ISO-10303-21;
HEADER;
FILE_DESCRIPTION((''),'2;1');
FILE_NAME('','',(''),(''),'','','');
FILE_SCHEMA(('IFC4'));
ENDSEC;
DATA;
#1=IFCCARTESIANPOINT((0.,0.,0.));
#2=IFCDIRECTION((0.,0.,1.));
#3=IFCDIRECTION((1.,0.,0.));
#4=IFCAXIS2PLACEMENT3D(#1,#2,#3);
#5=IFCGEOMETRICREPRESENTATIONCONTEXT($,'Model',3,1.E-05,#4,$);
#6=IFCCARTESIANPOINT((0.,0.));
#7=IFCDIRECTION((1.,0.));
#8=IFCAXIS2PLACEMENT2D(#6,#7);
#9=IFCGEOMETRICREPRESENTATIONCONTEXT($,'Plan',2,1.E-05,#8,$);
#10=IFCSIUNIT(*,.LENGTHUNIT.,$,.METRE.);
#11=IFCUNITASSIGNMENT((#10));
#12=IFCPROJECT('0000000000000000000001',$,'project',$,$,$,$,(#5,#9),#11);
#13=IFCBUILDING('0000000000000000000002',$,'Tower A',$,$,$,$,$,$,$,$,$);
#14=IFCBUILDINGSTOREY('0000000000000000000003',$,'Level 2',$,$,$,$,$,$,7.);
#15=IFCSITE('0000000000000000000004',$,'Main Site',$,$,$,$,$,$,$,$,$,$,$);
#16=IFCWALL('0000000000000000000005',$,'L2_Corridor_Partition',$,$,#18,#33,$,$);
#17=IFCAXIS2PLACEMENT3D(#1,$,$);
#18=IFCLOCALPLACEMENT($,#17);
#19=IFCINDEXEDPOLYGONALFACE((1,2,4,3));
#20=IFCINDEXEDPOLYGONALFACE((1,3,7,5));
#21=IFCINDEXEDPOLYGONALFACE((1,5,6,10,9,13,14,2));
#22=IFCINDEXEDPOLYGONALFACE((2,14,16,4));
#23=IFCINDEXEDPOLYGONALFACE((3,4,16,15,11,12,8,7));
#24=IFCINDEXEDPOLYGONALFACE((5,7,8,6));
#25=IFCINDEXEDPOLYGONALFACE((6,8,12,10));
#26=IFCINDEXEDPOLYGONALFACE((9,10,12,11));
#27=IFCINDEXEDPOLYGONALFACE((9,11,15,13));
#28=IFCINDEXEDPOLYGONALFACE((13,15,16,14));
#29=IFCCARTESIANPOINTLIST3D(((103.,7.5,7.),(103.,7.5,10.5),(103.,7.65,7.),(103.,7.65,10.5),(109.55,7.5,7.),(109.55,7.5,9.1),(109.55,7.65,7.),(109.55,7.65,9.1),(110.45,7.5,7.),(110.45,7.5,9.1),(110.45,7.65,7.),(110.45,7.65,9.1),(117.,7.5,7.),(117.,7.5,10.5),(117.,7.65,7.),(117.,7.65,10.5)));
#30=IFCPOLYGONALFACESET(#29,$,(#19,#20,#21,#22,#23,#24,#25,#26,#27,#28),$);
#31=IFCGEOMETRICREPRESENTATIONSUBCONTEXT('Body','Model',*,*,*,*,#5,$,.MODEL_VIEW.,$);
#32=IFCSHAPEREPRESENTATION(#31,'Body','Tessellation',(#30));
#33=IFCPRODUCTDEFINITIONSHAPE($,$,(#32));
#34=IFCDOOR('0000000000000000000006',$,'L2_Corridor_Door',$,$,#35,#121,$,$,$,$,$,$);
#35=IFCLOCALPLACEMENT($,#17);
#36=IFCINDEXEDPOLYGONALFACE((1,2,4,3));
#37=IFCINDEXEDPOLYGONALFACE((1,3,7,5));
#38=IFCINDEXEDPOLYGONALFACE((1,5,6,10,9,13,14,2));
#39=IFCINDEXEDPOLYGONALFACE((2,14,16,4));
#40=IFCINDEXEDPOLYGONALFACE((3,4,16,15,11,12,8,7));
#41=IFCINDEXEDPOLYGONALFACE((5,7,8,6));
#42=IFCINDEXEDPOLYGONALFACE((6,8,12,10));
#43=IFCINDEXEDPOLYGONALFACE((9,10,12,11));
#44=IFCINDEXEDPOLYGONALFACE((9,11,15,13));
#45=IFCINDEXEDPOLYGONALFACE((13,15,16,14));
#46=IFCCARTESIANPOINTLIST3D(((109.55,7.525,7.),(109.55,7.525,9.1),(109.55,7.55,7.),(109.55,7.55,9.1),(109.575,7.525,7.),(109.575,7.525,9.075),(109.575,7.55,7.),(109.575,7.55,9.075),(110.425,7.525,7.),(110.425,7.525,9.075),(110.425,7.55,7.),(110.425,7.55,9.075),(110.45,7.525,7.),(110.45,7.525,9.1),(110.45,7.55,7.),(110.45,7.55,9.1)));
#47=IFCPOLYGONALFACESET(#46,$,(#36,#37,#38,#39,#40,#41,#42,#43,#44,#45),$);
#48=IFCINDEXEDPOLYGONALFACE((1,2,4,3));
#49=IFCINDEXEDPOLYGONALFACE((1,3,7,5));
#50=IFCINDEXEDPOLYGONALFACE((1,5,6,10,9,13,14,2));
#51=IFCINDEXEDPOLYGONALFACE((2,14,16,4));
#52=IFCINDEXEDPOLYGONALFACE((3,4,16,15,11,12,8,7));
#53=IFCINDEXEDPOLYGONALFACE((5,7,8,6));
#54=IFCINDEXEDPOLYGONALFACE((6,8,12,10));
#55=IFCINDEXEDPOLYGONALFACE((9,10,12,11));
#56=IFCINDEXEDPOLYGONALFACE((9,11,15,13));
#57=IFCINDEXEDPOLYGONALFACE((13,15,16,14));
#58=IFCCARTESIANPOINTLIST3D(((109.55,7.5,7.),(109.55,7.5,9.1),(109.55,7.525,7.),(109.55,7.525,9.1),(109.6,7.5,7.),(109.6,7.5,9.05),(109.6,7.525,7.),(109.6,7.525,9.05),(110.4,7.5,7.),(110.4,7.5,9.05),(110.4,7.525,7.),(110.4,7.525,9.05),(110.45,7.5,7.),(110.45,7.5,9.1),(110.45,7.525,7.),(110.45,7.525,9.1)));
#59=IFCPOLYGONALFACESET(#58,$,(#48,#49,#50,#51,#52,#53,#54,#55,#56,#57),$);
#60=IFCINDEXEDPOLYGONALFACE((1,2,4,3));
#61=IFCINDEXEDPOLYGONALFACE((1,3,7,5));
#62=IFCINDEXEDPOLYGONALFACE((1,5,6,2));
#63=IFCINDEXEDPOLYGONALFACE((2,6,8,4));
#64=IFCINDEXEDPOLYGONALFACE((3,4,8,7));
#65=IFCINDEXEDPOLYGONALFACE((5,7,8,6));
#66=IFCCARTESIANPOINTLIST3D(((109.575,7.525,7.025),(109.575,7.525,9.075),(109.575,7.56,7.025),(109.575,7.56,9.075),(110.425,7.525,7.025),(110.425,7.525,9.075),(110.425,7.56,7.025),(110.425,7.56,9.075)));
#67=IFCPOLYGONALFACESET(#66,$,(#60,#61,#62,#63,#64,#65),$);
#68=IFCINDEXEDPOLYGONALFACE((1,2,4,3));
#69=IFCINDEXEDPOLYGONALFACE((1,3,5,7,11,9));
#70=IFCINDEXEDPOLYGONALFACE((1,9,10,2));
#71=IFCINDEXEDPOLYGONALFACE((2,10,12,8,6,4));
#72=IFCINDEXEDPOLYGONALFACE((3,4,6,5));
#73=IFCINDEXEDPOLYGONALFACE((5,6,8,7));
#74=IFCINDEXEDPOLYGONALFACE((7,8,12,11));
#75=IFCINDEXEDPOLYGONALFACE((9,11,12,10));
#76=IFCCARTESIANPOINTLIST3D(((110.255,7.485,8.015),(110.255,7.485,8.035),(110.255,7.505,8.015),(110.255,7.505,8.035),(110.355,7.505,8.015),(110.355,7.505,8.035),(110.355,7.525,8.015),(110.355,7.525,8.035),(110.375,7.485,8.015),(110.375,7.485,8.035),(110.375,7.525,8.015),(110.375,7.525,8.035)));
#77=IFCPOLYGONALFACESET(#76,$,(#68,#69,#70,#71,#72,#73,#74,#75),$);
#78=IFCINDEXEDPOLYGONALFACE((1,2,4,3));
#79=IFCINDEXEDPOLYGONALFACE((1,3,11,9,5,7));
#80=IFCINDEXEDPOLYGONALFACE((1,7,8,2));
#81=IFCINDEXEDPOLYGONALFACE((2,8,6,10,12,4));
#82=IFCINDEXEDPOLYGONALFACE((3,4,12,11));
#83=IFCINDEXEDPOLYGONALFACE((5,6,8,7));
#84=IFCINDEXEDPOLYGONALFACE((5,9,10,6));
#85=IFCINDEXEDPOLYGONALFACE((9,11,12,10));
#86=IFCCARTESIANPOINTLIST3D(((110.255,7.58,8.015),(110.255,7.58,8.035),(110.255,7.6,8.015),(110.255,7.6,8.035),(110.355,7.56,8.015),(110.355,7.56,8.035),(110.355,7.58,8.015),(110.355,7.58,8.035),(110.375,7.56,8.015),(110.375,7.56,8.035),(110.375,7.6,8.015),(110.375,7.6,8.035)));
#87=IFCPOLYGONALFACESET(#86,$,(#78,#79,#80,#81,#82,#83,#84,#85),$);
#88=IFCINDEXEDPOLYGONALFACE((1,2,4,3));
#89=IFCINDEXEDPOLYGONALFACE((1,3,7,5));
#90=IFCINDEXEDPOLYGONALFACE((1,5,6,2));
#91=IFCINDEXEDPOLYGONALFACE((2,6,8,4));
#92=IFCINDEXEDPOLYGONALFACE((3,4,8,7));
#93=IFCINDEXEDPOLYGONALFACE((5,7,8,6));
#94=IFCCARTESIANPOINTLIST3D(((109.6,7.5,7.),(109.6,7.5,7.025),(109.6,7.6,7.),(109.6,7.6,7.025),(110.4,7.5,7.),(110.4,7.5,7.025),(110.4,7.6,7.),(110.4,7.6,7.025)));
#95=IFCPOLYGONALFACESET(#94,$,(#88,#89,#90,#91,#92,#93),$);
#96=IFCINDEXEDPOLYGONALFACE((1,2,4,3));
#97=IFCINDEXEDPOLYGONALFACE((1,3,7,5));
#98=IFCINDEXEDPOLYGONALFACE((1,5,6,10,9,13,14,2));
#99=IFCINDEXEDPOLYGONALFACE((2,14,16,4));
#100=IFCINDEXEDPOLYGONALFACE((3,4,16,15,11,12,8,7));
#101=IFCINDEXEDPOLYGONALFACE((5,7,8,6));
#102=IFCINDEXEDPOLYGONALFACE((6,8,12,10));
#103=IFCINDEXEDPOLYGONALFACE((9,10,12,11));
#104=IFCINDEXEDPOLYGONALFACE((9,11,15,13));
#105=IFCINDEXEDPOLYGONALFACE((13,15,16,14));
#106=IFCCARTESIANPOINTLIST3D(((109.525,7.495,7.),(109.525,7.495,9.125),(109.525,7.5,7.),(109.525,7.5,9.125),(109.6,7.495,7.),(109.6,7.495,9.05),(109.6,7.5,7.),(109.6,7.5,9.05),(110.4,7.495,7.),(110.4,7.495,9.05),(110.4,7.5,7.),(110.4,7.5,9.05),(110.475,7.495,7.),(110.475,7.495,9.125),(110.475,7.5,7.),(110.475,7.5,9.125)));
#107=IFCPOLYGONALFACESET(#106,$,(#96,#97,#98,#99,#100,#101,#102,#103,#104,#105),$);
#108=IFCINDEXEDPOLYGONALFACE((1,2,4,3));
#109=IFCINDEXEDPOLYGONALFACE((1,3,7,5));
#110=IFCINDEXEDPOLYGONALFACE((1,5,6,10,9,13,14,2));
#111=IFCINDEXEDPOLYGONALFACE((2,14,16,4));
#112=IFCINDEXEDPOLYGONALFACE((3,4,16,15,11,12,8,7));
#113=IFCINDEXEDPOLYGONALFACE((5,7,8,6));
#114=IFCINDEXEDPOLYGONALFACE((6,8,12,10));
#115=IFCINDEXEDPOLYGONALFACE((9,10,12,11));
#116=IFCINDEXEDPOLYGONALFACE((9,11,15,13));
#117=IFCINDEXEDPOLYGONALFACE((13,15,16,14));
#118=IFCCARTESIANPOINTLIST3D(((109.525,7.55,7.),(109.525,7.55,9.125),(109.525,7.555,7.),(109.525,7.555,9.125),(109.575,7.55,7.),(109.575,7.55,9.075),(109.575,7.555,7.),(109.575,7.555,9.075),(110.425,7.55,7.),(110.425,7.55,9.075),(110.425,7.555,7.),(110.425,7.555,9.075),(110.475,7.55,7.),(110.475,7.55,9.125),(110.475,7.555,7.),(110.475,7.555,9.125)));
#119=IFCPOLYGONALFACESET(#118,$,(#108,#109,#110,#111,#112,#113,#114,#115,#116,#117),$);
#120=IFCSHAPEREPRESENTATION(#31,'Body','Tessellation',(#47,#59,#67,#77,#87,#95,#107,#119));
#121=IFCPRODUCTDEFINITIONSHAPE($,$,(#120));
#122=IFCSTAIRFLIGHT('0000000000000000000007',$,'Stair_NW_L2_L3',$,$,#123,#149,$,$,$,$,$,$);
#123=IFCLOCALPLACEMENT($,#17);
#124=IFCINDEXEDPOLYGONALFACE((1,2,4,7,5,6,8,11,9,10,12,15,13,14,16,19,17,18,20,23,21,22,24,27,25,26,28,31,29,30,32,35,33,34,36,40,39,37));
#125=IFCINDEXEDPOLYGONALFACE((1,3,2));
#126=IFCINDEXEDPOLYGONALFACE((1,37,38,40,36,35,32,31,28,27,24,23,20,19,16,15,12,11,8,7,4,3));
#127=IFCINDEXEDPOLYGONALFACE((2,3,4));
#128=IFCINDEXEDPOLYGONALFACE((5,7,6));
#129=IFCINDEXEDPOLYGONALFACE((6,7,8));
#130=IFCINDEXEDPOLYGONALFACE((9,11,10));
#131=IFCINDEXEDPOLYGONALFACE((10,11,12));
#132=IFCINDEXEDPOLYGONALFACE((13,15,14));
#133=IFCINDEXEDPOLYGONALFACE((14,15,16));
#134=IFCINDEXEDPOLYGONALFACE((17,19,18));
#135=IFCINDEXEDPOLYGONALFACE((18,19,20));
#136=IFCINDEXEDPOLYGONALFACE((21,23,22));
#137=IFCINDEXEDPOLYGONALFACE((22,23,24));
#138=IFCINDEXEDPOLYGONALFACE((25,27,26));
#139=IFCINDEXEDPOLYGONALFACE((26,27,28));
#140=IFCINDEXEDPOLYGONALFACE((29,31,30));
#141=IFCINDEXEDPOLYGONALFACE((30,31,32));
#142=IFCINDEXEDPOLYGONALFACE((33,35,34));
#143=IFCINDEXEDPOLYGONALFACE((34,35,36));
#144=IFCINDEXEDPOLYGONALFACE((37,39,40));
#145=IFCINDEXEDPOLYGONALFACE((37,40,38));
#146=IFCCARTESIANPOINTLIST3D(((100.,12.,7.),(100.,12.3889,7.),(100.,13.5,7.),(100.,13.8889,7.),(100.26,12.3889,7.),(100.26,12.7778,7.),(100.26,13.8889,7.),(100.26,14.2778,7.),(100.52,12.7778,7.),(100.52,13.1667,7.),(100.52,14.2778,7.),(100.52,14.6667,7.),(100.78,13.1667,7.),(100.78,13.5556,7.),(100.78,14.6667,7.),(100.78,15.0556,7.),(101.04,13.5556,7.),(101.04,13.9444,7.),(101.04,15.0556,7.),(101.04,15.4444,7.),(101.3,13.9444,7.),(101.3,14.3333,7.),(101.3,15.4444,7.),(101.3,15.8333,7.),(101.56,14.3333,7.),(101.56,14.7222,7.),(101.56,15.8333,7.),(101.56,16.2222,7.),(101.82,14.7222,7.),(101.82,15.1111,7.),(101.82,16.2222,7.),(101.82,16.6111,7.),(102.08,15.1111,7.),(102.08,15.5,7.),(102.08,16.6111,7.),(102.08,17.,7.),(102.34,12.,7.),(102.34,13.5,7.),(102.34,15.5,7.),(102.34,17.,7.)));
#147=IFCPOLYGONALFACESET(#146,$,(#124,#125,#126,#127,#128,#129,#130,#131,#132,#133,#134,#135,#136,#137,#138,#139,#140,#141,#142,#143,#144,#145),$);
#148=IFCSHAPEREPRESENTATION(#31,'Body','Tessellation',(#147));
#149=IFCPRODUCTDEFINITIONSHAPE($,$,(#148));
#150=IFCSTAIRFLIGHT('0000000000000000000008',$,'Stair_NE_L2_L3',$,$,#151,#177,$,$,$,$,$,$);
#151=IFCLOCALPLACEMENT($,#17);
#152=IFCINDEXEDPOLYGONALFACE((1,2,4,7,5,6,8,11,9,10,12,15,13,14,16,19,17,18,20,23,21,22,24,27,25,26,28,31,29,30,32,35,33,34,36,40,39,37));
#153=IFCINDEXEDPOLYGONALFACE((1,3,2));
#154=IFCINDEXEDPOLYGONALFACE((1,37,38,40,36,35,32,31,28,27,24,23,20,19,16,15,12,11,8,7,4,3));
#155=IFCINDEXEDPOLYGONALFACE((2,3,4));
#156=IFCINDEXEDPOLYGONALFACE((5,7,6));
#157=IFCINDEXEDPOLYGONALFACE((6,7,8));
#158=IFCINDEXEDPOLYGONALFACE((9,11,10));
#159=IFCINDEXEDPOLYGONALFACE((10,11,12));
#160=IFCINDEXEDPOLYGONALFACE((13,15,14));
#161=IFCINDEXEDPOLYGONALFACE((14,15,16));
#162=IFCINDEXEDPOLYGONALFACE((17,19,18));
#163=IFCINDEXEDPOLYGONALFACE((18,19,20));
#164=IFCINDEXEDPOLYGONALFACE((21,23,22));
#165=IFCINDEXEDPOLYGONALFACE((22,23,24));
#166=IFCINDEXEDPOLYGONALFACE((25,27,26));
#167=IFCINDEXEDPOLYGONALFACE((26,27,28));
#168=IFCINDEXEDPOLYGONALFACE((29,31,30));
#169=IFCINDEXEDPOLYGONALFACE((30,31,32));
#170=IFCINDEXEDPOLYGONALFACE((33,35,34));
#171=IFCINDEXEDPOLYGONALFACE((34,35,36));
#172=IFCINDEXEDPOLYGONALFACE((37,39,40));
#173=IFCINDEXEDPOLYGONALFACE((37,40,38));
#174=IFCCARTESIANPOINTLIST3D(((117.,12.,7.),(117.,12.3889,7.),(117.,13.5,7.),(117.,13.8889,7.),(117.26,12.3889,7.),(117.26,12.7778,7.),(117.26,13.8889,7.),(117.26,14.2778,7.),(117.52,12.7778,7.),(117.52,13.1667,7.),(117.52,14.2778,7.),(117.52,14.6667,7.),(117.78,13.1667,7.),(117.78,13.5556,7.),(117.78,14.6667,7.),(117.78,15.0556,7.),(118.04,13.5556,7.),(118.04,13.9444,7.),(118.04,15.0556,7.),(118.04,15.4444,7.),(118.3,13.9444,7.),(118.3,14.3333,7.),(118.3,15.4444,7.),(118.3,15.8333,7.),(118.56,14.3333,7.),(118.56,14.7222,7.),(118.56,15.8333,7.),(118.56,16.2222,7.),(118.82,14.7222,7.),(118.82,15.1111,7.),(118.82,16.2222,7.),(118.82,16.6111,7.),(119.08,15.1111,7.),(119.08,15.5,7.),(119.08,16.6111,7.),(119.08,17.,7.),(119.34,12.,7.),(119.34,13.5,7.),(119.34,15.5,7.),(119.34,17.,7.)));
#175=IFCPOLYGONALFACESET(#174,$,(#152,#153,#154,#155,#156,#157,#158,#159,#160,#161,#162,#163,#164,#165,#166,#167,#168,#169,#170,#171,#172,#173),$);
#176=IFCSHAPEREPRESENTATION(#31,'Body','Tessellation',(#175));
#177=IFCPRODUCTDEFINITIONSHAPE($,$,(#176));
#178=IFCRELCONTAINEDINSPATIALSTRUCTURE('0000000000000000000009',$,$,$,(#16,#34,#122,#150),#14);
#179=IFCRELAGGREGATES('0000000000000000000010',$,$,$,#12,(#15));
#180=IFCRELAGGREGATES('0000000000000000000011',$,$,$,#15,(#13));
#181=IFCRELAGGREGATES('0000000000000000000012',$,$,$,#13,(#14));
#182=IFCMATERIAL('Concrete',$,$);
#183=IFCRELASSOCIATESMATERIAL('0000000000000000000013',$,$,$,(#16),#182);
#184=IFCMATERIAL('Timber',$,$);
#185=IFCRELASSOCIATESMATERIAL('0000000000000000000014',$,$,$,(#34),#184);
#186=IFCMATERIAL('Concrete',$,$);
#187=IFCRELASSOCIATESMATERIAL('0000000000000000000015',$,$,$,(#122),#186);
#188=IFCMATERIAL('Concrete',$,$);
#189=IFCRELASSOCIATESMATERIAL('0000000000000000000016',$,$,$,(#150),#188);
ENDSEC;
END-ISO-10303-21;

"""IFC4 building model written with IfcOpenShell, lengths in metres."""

from ifc_helpers import new_model, si_unit, frame, origin_with_axes, origin_2d_with_axis, place, context, subcontext, project, spatial, line, indexed_curve, outline, extrude, material, element, fill, save


model = new_model("IFC4")

# Units and contexts
model_context = context("Model", 3, precision=1e-05, world=origin_with_axes())
plan_context = context("Plan", 2, precision=1e-05, world=origin_2d_with_axis())
body_context = subcontext(model_context, "Body", "Model", "MODEL_VIEW")
ifc_project = project(units=[si_unit("LENGTHUNIT", "METRE")], contexts=[model_context, plan_context])

# Site, building, storey
site = spatial("IfcSite", under=ifc_project, Name="Main Site")
building = spatial("IfcBuilding", under=site, Name="Tower A")
storey = spatial("IfcBuildingStorey", under=building, Name="Level 2", Elevation=7.0)

# Wall, opening, door
ifc_material_1 = material(Name="Concrete")
wall_1_placement = place(None, frame((103.0, 7.5, 7.0), z_axis=(0.0, 0.0, 1.0), x_axis=(1.0, 0.0, 0.0)))
wall_1 = element("IfcWall", 1, at=wall_1_placement, inside=storey, material=ifc_material_1, Name="L2_Corridor_Partition", context=body_context, shape_type="SweptSolid", body=[
    extrude(outline(indexed_curve([(0.0, 0.0), (0.0, 0.15), (14.0, 0.15), (14.0, 0.0), (0.0, 0.0)], self_intersect=False)), origin_with_axes(), (0.0, 0.0, 1.0), 3.5),
])
opening_1_placement = place(wall_1_placement, frame((6.55, 0.0, 0.0), z_axis=(0.0, 0.0, 1.0), x_axis=(1.0, 0.0, 0.0)))
opening_1 = element("IfcOpeningElement", 2, at=opening_1_placement, cuts=wall_1, context=body_context, shape_type="SweptSolid", body=[
    extrude(outline(indexed_curve([(0.0, 0.0), (0.0, 0.2), (0.9, 0.2), (0.9, 0.0), (0.0, 0.0)], self_intersect=False)), origin_with_axes(), (0.0, 0.0, 1.0), 2.1),
])
ifc_material_2 = material(Name="Timber")
door_placement = place(None, frame((109.55, 7.5, 7.0), z_axis=(0.0, 0.0, 1.0), x_axis=(1.0, 0.0, 0.0)))
door = element("IfcDoor", 3, at=door_placement, inside=storey, material=ifc_material_2, Name="L2_Corridor_Door", context=body_context, shape_type="SweptSolid", body=[
    extrude(outline(indexed_curve([(0.0, 0.0), (0.0, 2.1), (0.9, 2.1), (0.9, 0.0), (0.875, 0.0), (0.875, 2.075), (0.025, 2.075), (0.025, 0.0)], segments=[line(1, 2, 3, 4, 5, 6, 7, 8, 1)])), frame((0.0, 0.025, 0.0), z_axis=(0.0, -1.0, 0.0), x_axis=(1.0, 0.0, 0.0)), (0.0, 0.0, -1.0), 0.025),
    extrude(outline(indexed_curve([(0.0, 0.0), (0.0, 2.1), (0.9, 2.1), (0.9, 0.0), (0.85, 0.0), (0.85, 2.05), (0.05, 2.05), (0.05, 0.0)], segments=[line(1, 2, 3, 4, 5, 6, 7, 8, 1)])), frame((0.0, 0.0, 0.0), z_axis=(0.0, -1.0, 0.0), x_axis=(1.0, 0.0, 0.0)), (0.0, 0.0, -1.0), 0.025),
    extrude(outline(indexed_curve([(0.0, 0.0), (0.85, 0.0), (0.85, 0.035), (0.0, 0.035)], segments=[line(1, 2, 3, 4, 1)])), frame((0.025, 0.025, 0.025), z_axis=(0.0, 0.0, 1.0), x_axis=(1.0, 0.0, 0.0)), (0.0, 0.0, 1.0), 2.05),
    extrude(outline(indexed_curve([(0.0, 0.0), (0.0, -0.04), (-0.12, -0.04), (-0.12, -0.02), (-0.02, -0.02), (-0.02, 0.0)], segments=[line(1, 2, 3, 4, 5, 6, 1)])), frame((0.825, 0.025, 1.015), z_axis=(0.0, 0.0, 1.0), x_axis=(1.0, 0.0, 0.0)), (0.0, 0.0, 1.0), 0.02),
    extrude(outline(indexed_curve([(0.0, 0.0), (0.0, 0.04), (-0.12, 0.04), (-0.12, 0.02), (-0.02, 0.02), (-0.02, 0.0)], segments=[line(1, 2, 3, 4, 5, 6, 1)])), frame((0.825, 0.06, 1.015), z_axis=(0.0, 0.0, 1.0), x_axis=(1.0, 0.0, 0.0)), (0.0, 0.0, 1.0), 0.02),
    extrude(outline(indexed_curve([(0.0, 0.0), (0.8, 0.0), (0.8, 0.1), (0.0, 0.1)], segments=[line(1, 2, 3, 4, 1)])), frame((0.05, 0.0, 0.0), z_axis=(0.0, 0.0, 1.0), x_axis=(1.0, 0.0, 0.0)), (0.0, 0.0, 1.0), 0.025),
    extrude(outline(indexed_curve([(0.0, 0.0), (0.0, 2.125), (0.95, 2.125), (0.95, 0.0), (0.875, 0.0), (0.875, 2.05), (0.075, 2.05), (0.075, 0.0)], segments=[line(1, 2, 3, 4, 5, 6, 7, 8, 1)])), frame((-0.025, -0.005, 0.0), z_axis=(0.0, -1.0, 0.0), x_axis=(1.0, 0.0, 0.0)), (0.0, 0.0, -1.0), 0.005),
    extrude(outline(indexed_curve([(0.0, 0.0), (0.0, 2.125), (0.95, 2.125), (0.95, 0.0), (0.9, 0.0), (0.9, 2.075), (0.05, 2.075), (0.05, 0.0)], segments=[line(1, 2, 3, 4, 5, 6, 7, 8, 1)])), frame((-0.025, 0.05, 0.0), z_axis=(0.0, -1.0, 0.0), x_axis=(1.0, 0.0, 0.0)), (0.0, 0.0, -1.0), 0.005),
])
fill(opening_1, door)

# Stair flights
ifc_material_3 = material(Name="Concrete")
stair_flight_1_placement = place(None, frame((100.0, 12.0, 7.0), z_axis=(0.0, 0.0, 1.0), x_axis=(1.0, 0.0, 0.0)))
element("IfcStairFlight", 4, at=stair_flight_1_placement, inside=storey, material=ifc_material_3, Name="Stair_NW_L2_L3", context=body_context, shape_type="SweptSolid", body=[
    extrude(outline(indexed_curve([(0.0, 0.0), (0.0, 0.3889), (0.26, 0.3889), (0.26, 0.7778), (0.52, 0.7778), (0.52, 1.1667), (0.78, 1.1667), (0.78, 1.5556), (1.04, 1.5556), (1.04, 1.9444), (1.3, 1.9444), (1.3, 2.3333), (1.56, 2.3333), (1.56, 2.7222), (1.82, 2.7222), (1.82, 3.1111), (2.08, 3.1111), (2.08, 3.5), (2.34, 3.5), (2.34, 0.0)], segments=[line(1, 2, 3, 4, 5, 6, 7, 8, 9, 10, 11, 12, 13, 14, 15, 16, 17, 18, 19, 20, 1)])), origin_with_axes(), (0.0, 1.0, 0.0), 1.5),
])
ifc_material_4 = material(Name="Concrete")
stair_flight_2_placement = place(None, frame((117.0, 12.0, 7.0), z_axis=(0.0, 0.0, 1.0), x_axis=(1.0, 0.0, 0.0)))
element("IfcStairFlight", 5, at=stair_flight_2_placement, inside=storey, material=ifc_material_4, Name="Stair_NE_L2_L3", context=body_context, shape_type="SweptSolid", body=[
    extrude(outline(indexed_curve([(0.0, 0.0), (0.0, 0.3889), (0.26, 0.3889), (0.26, 0.7778), (0.52, 0.7778), (0.52, 1.1667), (0.78, 1.1667), (0.78, 1.5556), (1.04, 1.5556), (1.04, 1.9444), (1.3, 1.9444), (1.3, 2.3333), (1.56, 2.3333), (1.56, 2.7222), (1.82, 2.7222), (1.82, 3.1111), (2.08, 3.1111), (2.08, 3.5), (2.34, 3.5), (2.34, 0.0)], segments=[line(1, 2, 3, 4, 5, 6, 7, 8, 9, 10, 11, 12, 13, 14, 15, 16, 17, 18, 19, 20, 1)])), origin_with_axes(), (0.0, 1.0, 0.0), 1.5),
])

save(model, "model.ifc")
